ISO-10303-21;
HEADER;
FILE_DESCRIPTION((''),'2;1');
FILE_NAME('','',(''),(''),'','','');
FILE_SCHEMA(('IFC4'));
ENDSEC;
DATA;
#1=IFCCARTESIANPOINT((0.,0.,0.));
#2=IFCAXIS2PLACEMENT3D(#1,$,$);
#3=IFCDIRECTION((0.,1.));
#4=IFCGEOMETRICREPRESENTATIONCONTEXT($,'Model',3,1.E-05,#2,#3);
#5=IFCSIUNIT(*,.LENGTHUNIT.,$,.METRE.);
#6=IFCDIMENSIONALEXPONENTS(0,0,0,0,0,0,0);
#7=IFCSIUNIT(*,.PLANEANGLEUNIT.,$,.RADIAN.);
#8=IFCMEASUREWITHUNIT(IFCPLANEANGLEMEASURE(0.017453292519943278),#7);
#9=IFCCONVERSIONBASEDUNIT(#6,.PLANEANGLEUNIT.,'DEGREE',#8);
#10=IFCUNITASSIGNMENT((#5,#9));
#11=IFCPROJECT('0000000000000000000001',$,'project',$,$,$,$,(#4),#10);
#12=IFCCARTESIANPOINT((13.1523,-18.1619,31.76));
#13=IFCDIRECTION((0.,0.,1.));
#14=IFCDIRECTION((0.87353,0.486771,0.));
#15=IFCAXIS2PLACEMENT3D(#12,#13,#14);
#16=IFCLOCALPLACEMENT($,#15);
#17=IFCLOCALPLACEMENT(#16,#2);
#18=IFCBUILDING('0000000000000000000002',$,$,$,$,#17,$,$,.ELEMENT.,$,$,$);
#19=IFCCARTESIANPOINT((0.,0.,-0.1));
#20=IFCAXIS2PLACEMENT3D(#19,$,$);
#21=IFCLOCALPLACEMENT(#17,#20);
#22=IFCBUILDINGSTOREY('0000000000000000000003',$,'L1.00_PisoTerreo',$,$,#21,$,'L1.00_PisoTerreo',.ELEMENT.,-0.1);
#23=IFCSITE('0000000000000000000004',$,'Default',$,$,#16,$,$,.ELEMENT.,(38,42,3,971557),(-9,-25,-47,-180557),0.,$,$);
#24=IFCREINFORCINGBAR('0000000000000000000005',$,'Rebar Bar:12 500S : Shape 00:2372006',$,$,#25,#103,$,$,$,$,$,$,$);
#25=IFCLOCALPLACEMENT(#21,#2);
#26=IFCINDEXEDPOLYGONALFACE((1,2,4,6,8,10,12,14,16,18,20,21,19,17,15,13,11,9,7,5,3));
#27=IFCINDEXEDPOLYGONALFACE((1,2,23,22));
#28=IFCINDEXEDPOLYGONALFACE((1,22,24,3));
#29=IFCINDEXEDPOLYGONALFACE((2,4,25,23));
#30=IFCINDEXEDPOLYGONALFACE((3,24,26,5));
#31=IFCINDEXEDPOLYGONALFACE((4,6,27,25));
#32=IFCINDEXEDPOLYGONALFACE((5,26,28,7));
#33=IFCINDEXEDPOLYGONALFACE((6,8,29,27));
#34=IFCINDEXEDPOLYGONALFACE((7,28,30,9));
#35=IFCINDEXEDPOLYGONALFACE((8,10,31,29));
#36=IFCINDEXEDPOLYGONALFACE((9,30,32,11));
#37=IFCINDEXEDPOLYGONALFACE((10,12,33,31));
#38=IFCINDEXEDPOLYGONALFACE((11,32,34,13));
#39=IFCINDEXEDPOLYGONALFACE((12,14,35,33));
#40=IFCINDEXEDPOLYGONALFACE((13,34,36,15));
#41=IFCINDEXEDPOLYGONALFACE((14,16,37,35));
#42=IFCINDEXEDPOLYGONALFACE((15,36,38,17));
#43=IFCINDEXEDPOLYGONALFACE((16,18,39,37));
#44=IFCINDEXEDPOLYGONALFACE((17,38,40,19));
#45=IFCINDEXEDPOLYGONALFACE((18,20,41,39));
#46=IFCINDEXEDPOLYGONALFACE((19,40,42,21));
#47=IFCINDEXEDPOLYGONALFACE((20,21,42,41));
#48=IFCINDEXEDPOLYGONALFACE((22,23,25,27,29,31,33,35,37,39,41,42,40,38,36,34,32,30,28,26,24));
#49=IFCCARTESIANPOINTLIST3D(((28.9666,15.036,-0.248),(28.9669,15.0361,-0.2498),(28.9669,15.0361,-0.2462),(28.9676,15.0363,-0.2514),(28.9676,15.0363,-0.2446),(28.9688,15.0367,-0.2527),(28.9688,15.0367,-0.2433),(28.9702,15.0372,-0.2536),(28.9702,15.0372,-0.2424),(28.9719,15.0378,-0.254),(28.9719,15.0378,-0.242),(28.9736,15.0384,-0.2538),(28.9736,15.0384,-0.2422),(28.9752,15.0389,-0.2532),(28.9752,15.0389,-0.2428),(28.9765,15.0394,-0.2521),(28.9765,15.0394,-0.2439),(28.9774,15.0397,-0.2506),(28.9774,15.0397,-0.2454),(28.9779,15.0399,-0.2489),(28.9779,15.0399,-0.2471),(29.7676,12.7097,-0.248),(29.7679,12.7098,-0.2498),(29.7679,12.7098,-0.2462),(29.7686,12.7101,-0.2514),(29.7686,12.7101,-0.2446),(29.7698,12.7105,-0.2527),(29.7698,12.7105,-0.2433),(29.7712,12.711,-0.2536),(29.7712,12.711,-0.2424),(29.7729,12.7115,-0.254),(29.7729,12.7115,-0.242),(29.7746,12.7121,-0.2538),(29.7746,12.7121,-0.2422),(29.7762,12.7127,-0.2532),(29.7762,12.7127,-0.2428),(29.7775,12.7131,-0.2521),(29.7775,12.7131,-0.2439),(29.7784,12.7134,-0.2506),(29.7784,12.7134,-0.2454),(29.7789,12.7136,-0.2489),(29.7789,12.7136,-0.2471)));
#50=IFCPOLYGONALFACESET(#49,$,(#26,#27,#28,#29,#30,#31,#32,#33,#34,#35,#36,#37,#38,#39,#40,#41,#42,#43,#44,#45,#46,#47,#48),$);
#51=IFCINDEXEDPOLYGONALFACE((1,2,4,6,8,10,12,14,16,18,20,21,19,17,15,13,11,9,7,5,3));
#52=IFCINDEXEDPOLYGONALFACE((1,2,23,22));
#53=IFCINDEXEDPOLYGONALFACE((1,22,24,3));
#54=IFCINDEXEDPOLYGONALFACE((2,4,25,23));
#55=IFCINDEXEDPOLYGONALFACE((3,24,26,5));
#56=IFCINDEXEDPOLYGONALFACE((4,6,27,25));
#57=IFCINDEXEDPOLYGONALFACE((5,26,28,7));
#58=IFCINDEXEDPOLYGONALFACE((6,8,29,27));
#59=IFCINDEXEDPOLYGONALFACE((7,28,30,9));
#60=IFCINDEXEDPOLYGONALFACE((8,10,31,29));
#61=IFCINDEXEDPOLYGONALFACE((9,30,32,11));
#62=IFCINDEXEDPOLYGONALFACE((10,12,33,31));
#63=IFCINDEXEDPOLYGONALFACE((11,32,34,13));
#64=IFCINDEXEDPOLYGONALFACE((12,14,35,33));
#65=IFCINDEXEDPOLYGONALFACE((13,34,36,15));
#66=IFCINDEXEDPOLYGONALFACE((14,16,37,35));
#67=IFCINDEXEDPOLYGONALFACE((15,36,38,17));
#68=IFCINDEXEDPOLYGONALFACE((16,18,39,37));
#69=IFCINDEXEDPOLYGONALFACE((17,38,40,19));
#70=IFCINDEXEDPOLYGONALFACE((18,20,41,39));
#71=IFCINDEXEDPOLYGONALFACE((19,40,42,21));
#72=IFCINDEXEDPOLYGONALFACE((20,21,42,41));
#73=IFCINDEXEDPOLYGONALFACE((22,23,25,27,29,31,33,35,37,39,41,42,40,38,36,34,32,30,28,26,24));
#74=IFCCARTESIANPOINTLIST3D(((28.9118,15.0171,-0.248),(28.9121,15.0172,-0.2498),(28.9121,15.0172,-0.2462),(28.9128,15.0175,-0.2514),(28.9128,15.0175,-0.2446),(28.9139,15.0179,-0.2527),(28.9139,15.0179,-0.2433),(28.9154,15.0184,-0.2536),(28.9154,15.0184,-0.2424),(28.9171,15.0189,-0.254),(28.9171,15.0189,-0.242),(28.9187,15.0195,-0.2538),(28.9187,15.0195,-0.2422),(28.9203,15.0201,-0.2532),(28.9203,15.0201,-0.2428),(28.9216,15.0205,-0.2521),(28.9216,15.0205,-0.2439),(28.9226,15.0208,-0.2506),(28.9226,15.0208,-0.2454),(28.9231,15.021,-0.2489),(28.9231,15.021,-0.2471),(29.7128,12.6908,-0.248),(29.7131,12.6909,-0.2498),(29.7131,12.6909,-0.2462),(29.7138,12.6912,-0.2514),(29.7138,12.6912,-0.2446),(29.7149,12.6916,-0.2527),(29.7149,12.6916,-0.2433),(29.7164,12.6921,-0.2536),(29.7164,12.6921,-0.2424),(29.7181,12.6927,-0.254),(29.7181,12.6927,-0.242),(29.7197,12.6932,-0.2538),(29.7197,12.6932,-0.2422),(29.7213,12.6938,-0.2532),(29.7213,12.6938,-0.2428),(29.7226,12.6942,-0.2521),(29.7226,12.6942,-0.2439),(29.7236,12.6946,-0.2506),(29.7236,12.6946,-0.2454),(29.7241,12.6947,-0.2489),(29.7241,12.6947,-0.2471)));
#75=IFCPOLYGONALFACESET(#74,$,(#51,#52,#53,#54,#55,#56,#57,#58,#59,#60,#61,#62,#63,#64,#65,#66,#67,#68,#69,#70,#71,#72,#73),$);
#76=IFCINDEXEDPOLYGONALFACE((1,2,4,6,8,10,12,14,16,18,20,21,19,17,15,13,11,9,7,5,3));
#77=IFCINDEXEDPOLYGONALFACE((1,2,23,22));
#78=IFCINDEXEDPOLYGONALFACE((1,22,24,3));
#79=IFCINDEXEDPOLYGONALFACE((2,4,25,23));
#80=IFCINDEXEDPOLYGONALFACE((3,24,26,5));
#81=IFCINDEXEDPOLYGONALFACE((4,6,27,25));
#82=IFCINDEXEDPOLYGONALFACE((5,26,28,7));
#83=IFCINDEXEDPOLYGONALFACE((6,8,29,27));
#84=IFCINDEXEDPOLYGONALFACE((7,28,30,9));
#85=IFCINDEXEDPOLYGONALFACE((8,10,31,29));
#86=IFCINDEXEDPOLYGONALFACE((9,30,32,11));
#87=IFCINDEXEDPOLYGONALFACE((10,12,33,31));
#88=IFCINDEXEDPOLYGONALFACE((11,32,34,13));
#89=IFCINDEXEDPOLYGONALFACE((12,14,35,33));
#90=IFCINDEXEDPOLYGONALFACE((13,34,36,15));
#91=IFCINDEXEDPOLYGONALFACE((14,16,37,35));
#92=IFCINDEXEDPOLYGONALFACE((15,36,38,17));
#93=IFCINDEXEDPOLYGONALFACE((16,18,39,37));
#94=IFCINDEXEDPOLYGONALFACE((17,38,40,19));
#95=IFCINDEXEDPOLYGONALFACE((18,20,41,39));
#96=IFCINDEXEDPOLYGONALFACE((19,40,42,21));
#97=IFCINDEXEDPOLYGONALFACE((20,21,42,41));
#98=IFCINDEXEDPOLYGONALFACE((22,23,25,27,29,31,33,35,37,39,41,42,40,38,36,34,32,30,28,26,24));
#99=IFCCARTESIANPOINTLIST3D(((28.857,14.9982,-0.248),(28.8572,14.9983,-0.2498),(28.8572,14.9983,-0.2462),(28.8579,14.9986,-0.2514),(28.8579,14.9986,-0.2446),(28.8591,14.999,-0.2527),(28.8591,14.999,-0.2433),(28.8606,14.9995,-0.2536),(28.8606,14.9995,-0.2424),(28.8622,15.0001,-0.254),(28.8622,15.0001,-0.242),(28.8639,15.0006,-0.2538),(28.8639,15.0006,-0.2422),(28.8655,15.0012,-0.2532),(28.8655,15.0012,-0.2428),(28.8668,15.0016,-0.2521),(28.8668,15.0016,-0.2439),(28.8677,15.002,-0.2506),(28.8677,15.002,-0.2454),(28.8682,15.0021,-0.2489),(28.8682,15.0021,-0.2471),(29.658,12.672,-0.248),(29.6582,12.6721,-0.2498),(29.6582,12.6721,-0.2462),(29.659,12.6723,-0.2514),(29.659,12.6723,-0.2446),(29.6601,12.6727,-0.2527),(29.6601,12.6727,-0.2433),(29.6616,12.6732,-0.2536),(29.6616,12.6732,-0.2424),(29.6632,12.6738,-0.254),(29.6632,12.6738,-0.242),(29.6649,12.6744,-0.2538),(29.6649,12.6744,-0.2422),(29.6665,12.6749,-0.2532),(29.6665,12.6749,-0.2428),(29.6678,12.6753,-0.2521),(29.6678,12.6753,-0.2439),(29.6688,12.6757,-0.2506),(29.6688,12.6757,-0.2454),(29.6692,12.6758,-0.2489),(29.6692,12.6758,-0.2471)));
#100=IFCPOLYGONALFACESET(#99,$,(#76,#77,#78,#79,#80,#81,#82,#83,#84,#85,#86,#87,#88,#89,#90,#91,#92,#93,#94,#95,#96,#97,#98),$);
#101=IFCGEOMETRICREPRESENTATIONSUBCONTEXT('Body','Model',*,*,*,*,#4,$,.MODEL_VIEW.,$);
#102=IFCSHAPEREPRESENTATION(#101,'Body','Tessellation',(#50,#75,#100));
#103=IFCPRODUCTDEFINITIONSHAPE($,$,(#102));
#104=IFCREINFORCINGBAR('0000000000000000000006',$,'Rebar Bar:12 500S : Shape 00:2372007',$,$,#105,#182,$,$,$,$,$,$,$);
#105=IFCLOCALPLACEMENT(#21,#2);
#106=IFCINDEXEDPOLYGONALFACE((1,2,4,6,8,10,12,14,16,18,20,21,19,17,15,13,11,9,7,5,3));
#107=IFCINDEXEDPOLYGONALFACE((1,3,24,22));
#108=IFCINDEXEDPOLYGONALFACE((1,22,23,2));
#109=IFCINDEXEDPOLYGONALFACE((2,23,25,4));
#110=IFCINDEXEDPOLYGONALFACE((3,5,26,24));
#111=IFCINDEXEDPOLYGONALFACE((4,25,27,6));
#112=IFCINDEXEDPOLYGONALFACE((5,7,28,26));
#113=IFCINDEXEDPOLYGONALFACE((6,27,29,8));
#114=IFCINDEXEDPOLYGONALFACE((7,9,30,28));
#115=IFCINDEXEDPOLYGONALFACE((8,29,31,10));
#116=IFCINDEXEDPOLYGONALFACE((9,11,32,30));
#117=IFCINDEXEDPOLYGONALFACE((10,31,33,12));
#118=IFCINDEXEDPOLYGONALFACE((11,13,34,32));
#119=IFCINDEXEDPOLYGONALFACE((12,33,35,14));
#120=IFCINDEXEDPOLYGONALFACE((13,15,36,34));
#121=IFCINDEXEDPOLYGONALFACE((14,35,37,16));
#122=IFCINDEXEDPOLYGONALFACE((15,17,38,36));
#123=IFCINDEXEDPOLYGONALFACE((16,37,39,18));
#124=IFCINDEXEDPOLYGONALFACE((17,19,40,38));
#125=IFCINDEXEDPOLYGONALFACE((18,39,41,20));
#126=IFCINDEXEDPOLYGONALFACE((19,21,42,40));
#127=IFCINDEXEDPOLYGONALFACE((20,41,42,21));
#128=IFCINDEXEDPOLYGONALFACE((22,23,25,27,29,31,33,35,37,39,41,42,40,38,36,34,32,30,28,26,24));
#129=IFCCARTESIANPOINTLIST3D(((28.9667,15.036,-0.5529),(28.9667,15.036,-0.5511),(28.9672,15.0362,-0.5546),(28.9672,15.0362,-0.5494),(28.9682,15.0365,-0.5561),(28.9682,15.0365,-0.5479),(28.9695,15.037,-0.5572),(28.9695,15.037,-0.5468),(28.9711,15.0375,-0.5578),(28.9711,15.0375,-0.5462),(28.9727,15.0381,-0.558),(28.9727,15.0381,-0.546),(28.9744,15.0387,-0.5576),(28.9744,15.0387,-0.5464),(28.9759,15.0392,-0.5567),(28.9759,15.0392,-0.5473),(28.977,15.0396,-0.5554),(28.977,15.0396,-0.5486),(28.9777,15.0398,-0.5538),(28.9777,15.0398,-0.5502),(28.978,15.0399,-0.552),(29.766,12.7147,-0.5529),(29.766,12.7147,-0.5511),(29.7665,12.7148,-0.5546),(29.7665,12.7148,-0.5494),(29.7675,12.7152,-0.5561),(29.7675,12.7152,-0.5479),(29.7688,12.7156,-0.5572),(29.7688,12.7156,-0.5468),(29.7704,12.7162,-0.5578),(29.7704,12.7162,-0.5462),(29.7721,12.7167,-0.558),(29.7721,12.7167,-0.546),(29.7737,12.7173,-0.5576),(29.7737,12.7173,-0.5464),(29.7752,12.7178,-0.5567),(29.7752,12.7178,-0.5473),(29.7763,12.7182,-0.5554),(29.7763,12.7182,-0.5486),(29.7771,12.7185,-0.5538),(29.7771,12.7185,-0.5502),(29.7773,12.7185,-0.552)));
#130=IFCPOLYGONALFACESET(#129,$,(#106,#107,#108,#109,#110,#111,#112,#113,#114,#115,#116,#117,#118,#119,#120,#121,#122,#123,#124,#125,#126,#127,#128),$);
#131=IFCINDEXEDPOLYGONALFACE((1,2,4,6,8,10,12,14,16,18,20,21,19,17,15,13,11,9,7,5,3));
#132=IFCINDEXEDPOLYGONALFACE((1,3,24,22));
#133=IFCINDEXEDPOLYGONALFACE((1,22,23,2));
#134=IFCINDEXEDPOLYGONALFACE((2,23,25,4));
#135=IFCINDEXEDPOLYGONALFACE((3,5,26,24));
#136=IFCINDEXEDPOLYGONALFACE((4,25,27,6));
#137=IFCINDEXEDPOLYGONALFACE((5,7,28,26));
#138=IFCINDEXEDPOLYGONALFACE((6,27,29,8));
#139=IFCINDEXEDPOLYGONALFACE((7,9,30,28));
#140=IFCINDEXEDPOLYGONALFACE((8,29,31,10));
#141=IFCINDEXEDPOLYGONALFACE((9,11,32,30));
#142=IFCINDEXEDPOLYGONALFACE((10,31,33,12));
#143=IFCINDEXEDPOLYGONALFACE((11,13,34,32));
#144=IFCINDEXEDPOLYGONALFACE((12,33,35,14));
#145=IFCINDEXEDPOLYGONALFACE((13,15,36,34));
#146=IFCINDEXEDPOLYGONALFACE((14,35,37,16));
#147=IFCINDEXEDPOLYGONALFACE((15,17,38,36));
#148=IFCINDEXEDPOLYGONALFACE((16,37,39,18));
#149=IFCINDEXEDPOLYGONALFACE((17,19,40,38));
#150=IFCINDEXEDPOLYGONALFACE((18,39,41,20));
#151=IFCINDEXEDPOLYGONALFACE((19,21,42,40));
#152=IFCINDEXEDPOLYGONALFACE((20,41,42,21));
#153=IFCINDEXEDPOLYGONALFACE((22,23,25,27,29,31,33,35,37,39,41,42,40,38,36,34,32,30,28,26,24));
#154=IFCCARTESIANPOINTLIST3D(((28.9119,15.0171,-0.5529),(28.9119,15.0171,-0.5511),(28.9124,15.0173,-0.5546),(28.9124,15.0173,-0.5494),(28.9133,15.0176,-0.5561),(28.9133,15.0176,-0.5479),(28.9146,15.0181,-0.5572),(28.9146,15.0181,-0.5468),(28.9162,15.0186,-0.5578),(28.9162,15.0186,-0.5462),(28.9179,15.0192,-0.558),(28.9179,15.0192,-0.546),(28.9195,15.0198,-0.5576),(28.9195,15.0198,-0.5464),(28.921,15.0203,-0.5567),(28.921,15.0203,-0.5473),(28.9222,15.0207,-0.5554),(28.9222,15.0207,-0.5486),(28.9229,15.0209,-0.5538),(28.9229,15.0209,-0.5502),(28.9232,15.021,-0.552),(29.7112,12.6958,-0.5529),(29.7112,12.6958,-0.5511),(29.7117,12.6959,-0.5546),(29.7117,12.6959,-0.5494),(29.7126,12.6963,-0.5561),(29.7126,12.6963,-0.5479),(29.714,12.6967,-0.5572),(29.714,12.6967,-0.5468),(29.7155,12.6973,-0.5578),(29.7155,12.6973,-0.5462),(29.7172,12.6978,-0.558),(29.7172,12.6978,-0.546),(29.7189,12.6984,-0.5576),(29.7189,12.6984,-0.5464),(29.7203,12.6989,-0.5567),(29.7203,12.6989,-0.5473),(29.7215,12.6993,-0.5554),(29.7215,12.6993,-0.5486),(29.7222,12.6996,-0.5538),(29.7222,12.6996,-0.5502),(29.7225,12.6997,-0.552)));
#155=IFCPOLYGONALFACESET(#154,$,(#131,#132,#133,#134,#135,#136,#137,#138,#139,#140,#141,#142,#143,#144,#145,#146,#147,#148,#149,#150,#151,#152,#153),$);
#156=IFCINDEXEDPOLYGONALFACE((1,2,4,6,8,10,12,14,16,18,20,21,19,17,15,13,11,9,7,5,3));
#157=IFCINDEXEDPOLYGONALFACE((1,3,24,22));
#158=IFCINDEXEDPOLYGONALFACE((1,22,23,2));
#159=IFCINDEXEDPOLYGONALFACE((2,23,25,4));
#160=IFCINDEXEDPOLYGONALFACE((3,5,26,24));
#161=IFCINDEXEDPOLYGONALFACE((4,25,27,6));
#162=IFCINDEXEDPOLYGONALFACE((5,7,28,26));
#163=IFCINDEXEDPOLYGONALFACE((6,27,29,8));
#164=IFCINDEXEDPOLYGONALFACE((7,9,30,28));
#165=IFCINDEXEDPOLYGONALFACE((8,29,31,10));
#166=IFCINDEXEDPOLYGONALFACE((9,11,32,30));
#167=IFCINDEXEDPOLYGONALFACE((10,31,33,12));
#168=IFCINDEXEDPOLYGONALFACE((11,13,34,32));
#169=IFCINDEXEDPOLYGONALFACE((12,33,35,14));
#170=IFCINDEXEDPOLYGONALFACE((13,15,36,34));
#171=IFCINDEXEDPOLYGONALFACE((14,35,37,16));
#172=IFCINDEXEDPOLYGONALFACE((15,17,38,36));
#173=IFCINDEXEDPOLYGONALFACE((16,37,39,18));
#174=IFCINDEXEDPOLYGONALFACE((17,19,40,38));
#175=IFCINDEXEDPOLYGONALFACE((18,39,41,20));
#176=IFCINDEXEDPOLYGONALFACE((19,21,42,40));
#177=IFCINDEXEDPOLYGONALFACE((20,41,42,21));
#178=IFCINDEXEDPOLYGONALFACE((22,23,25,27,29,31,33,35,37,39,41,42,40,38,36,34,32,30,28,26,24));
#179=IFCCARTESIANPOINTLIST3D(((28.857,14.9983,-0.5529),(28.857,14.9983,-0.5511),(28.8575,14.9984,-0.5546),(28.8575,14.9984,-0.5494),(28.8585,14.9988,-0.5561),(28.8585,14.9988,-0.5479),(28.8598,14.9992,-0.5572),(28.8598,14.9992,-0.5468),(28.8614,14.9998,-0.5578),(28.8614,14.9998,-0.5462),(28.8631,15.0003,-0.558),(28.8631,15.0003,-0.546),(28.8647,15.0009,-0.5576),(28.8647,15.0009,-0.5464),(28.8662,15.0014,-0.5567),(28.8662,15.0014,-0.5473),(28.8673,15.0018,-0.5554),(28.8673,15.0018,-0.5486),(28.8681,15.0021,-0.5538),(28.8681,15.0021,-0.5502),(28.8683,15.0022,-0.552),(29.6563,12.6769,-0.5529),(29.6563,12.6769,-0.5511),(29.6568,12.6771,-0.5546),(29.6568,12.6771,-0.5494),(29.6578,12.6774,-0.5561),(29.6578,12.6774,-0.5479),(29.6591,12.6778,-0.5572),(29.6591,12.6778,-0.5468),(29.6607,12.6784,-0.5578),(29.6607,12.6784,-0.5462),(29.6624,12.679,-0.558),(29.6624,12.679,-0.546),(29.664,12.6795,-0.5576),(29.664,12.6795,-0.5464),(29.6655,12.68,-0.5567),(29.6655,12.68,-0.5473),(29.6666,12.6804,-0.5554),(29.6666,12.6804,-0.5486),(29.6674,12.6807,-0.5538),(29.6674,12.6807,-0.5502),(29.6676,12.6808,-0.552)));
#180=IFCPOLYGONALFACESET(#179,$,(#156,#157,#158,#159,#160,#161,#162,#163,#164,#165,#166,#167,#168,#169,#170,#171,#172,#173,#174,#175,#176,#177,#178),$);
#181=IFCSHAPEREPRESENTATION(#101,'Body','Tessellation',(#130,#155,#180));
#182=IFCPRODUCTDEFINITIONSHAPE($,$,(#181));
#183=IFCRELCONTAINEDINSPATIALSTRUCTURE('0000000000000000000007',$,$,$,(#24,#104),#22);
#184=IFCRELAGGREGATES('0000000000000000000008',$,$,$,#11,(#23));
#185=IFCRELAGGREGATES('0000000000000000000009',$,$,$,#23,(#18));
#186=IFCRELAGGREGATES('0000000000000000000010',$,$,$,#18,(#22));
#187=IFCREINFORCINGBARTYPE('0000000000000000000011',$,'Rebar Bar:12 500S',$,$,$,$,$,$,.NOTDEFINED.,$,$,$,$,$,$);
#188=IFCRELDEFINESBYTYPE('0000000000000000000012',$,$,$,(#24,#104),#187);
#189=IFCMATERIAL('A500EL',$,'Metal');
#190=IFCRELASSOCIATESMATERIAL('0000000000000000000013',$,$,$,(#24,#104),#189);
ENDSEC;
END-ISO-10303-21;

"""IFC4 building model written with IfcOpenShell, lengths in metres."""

from ifc_helpers import new_model, entity, si_unit, converted_unit, direction, frame, origin, place, context, subcontext, project, spatial, material, type_object, element, save


model = new_model("IFC4")

# Units and contexts
model_context = context("Model", 3, precision=1e-05, world=origin(), true_north=direction((0.0, 1.0)))
body_context = subcontext(model_context, "Body", "Model", "MODEL_VIEW")
ifc_project = project(units=[si_unit("LENGTHUNIT", "METRE"), converted_unit("PLANEANGLEUNIT", "DEGREE", entity("IfcPlaneAngleMeasure", 0.017453292519943278), si_unit("PLANEANGLEUNIT", "RADIAN"), dimensions=[0, 0, 0, 0, 0, 0, 0])], contexts=[model_context])

# Site, building, storey
site_placement = place(None, frame((13.1523, -18.1619, 31.76), z_axis=(0.0, 0.0, 1.0), x_axis=(0.87353, 0.486771, 0.0)))
site = spatial("IfcSite", under=ifc_project, at=site_placement, Name="Default", CompositionType="ELEMENT", RefLatitude=(38, 42, 3, 971557), RefLongitude=(-9, -25, -47, -180557), RefElevation=0.0)
building_placement = place(site_placement, origin())
building = spatial("IfcBuilding", under=site, at=building_placement, CompositionType="ELEMENT")
storey_placement = place(building_placement, frame((0.0, 0.0, -0.1)))
storey = spatial("IfcBuildingStorey", under=building, at=storey_placement, Name="L1.00_PisoTerreo", LongName="L1.00_PisoTerreo", CompositionType="ELEMENT", Elevation=-0.1)

# Reinforcing bars
ifc_material = material(Name="A500EL", Category="Metal")
reinforcing_bar_type_1 = type_object("IfcReinforcingBarType", Name="Rebar Bar:12 500S", PredefinedType="NOTDEFINED")
reinforcing_bar_1_placement = place(storey_placement, origin())
element("IfcReinforcingBar", 1, at=reinforcing_bar_1_placement, inside=storey, type_object=reinforcing_bar_type_1, material=ifc_material, Name="Rebar Bar:12 500S : Shape 00:2372006", context=body_context, shape_type="AdvancedSweptSolid", body=[
    entity("IfcSweptDiskSolid", entity("IfcIndexedPolyCurve", entity("IfcCartesianPointList3D", [[28.9723, 15.038, -0.248], [29.7733, 12.7117, -0.248]]), None, False), 0.006, None, 0.0, 1.0),
    entity("IfcSweptDiskSolid", entity("IfcIndexedPolyCurve", entity("IfcCartesianPointList3D", [[28.9175, 15.0191, -0.248], [29.7185, 12.6928, -0.248]]), None, False), 0.006, None, 0.0, 1.0),
    entity("IfcSweptDiskSolid", entity("IfcIndexedPolyCurve", entity("IfcCartesianPointList3D", [[28.8626, 15.0002, -0.248], [29.6636, 12.6739, -0.248]]), None, False), 0.006, None, 0.0, 1.0),
])
reinforcing_bar_2_placement = place(storey_placement, origin())
element("IfcReinforcingBar", 2, at=reinforcing_bar_2_placement, inside=storey, type_object=reinforcing_bar_type_1, material=ifc_material, Name="Rebar Bar:12 500S : Shape 00:2372007", context=body_context, shape_type="AdvancedSweptSolid", body=[
    entity("IfcSweptDiskSolid", entity("IfcIndexedPolyCurve", entity("IfcCartesianPointList3D", [[29.7716, 12.7166, -0.552], [28.9723, 15.038, -0.552]]), None, False), 0.006, None, 0.0, 1.0),
    entity("IfcSweptDiskSolid", entity("IfcIndexedPolyCurve", entity("IfcCartesianPointList3D", [[29.7168, 12.6977, -0.552], [28.9175, 15.0191, -0.552]]), None, False), 0.006, None, 0.0, 1.0),
    entity("IfcSweptDiskSolid", entity("IfcIndexedPolyCurve", entity("IfcCartesianPointList3D", [[29.662, 12.6788, -0.552], [28.8626, 15.0002, -0.552]]), None, False), 0.006, None, 0.0, 1.0),
])

save(model, "model.ifc")
